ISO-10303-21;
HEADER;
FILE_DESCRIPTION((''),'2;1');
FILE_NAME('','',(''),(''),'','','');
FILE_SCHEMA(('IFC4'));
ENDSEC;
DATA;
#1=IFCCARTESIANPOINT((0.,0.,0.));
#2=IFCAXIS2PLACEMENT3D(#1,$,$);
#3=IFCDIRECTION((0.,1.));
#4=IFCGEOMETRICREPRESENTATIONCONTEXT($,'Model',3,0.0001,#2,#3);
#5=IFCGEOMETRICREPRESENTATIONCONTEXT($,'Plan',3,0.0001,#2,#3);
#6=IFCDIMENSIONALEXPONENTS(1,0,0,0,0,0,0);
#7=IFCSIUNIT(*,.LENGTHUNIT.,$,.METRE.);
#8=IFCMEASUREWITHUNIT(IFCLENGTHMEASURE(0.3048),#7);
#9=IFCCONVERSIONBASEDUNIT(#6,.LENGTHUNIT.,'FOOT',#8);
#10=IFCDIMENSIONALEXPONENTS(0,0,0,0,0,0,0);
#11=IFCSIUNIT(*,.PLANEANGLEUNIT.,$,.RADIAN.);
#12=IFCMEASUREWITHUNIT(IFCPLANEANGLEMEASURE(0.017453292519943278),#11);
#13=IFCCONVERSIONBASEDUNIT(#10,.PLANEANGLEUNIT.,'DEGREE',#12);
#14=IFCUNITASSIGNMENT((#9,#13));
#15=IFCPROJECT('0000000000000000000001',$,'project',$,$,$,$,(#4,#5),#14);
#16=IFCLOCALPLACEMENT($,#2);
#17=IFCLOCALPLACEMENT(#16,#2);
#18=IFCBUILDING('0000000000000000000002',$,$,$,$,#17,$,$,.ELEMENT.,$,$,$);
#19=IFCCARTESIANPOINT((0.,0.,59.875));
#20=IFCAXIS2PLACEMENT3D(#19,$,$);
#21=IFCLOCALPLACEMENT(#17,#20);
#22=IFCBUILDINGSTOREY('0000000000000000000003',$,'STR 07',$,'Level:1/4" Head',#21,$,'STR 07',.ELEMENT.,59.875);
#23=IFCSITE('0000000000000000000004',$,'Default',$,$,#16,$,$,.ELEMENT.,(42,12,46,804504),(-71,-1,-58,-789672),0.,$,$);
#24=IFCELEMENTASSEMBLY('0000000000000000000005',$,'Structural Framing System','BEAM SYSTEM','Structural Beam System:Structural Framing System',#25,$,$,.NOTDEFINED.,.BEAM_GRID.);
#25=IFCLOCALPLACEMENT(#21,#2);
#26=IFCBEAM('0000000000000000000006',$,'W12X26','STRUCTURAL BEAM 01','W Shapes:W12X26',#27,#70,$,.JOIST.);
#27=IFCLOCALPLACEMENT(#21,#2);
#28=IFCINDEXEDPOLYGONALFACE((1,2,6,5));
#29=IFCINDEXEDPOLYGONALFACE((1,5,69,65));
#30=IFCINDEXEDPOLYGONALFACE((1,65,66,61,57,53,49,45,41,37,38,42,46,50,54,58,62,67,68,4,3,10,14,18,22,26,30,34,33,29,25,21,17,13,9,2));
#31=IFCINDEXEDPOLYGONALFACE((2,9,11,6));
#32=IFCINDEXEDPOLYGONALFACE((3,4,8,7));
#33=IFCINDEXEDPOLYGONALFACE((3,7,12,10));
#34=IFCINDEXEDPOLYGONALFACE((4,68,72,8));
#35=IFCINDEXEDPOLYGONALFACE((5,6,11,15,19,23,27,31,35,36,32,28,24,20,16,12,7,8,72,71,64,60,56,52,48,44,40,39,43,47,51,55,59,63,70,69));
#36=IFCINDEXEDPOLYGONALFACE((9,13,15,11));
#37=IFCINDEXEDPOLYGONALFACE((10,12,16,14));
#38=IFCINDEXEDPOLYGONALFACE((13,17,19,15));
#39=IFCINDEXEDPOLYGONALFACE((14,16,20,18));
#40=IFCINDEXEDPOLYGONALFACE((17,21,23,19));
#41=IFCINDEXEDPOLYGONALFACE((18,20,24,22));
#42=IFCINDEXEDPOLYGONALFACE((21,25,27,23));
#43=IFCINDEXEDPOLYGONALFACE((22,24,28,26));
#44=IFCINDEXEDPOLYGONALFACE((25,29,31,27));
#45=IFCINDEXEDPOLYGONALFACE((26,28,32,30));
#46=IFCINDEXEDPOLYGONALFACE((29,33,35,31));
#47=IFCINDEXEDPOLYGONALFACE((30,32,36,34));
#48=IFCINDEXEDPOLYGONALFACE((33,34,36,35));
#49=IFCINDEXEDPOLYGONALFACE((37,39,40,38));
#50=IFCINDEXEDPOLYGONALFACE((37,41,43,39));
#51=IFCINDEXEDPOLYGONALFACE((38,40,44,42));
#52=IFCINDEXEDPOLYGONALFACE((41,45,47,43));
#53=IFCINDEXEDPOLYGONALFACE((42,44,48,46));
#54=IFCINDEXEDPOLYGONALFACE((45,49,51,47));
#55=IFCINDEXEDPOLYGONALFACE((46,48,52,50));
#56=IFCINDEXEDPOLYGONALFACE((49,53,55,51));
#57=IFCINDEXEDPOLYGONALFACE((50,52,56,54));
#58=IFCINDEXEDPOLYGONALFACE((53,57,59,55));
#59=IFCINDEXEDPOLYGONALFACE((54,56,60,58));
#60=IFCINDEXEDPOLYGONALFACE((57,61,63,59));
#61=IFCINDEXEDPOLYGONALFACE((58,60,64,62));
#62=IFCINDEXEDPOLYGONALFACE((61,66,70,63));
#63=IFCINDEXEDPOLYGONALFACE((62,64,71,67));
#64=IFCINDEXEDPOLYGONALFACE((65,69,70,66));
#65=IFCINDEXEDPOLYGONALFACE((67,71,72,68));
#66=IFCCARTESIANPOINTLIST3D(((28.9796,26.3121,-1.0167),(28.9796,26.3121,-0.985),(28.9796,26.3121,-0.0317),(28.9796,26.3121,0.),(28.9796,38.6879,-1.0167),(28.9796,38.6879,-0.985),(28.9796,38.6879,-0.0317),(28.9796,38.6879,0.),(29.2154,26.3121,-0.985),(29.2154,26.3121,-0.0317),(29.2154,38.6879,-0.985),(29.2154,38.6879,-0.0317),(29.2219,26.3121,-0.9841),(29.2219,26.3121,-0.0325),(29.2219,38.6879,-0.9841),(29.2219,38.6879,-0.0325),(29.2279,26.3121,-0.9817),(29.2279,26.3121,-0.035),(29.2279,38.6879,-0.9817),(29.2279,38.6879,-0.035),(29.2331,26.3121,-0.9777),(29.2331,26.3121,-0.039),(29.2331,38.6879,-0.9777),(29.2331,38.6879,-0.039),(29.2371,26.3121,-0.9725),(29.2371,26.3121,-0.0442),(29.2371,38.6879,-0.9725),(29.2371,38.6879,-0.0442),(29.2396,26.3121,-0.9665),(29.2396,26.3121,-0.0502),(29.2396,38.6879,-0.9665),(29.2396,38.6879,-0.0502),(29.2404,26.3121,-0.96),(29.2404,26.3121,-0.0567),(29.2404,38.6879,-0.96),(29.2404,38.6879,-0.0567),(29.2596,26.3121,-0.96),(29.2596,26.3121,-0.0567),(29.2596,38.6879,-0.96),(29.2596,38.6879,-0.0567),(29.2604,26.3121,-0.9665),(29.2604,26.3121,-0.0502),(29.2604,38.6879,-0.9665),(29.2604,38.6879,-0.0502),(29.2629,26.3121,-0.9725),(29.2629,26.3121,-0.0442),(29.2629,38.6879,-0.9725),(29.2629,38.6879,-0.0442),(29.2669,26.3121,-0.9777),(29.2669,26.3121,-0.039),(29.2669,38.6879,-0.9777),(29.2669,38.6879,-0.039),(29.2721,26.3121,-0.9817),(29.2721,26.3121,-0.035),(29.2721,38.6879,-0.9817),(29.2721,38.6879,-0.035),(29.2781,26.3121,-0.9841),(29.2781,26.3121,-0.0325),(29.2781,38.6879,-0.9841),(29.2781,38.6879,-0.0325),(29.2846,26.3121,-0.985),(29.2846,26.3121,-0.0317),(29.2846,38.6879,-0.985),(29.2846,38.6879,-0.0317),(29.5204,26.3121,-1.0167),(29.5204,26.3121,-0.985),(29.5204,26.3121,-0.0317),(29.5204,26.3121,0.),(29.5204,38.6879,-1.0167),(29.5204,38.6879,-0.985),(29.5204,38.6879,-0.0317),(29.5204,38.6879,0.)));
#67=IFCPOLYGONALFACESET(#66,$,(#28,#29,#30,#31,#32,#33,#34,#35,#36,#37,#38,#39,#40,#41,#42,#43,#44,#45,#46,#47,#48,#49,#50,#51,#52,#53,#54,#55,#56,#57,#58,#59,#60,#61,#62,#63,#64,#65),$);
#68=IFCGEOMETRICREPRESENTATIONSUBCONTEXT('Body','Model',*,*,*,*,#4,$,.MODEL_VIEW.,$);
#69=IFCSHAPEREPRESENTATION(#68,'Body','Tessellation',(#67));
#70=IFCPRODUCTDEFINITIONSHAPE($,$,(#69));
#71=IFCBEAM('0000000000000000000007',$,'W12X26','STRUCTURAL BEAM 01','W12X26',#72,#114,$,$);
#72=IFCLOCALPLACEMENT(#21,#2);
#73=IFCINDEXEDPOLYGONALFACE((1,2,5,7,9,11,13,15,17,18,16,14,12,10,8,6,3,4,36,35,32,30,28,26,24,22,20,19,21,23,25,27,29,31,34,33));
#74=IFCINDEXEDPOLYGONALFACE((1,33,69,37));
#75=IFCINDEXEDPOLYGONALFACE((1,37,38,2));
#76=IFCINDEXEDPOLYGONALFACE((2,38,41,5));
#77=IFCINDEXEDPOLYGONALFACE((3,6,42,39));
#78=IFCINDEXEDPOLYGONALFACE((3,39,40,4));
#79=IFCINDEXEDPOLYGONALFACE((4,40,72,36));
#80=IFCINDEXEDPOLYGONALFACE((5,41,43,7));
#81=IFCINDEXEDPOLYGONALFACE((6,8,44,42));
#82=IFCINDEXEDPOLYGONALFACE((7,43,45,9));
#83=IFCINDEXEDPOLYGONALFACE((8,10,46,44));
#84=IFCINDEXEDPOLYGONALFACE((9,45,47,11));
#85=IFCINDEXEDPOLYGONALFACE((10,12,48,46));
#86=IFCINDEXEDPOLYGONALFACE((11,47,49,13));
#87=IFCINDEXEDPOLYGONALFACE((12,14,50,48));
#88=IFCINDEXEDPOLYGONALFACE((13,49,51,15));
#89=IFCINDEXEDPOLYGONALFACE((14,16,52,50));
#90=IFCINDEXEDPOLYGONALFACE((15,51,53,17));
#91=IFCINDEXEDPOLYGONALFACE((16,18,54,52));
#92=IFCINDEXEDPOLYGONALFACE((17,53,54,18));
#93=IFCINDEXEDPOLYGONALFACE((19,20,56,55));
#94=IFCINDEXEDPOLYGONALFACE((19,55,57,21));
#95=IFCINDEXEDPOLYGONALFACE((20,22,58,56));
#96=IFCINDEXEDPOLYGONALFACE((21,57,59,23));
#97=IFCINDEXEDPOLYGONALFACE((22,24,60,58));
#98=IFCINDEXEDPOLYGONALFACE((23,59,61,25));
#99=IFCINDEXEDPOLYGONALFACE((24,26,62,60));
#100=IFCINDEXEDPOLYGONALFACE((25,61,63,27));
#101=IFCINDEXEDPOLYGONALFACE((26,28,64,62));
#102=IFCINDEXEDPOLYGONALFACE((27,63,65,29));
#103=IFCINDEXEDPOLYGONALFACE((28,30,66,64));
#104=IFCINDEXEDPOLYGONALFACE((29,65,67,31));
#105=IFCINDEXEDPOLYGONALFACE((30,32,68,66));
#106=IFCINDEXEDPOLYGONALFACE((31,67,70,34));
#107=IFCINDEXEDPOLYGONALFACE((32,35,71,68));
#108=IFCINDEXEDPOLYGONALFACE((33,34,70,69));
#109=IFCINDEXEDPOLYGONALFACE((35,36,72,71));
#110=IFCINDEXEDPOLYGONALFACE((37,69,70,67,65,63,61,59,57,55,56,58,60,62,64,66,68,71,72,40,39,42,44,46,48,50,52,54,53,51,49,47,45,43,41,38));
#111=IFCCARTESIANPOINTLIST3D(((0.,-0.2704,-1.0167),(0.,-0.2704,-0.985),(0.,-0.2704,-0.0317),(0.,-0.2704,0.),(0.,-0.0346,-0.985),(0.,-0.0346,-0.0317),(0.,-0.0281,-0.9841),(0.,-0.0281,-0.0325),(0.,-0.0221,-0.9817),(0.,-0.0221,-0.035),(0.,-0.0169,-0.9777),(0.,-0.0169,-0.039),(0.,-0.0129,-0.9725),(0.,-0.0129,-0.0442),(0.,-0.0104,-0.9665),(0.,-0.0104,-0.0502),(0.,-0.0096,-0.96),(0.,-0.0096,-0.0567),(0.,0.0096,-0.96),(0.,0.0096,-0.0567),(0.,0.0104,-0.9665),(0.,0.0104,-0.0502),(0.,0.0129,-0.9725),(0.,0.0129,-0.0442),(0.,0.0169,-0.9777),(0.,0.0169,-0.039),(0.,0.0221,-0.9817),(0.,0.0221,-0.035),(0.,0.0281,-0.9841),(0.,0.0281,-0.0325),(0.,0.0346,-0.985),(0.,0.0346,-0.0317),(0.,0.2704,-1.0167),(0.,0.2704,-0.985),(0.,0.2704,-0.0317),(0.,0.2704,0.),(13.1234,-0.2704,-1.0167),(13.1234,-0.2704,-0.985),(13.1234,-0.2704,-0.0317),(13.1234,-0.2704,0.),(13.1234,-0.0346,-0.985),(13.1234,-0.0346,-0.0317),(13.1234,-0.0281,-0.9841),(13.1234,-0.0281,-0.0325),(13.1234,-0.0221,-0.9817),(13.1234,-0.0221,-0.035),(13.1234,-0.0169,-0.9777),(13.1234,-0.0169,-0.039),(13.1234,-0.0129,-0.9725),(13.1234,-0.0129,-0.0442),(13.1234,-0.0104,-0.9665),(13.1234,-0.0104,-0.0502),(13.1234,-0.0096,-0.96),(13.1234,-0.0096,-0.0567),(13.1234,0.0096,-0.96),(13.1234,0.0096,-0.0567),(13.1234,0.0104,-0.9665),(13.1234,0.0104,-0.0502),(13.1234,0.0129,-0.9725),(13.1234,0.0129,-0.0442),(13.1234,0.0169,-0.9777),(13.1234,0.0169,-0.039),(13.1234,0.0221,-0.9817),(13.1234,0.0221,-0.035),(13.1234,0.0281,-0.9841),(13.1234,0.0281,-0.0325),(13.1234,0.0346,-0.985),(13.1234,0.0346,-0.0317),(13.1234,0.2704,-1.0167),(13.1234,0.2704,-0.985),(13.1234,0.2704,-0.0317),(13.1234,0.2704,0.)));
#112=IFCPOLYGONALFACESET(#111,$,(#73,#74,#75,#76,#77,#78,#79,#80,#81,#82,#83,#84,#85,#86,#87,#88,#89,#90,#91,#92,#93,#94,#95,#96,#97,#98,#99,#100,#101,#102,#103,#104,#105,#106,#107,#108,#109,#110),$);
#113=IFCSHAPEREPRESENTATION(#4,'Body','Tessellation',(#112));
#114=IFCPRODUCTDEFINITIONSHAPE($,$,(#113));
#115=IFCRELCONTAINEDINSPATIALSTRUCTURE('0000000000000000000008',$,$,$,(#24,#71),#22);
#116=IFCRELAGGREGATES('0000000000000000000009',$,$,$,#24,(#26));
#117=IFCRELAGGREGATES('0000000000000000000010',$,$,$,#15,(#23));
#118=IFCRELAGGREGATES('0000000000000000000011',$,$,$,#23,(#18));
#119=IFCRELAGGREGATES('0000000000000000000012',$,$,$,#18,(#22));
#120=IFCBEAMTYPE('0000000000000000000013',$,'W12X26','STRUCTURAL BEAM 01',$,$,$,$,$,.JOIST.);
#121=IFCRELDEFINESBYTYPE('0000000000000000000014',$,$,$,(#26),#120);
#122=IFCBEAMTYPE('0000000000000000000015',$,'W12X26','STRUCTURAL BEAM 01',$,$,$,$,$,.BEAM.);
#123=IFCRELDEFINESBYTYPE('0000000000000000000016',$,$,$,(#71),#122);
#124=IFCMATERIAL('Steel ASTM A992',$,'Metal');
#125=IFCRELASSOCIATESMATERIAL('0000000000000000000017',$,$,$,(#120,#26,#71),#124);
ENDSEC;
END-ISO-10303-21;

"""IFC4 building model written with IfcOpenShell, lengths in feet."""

from ifc_helpers import new_model, entity, si_unit, converted_unit, direction, frame, origin, origin_2d, place, context, subcontext, project, spatial, line, arc, indexed_curve, i_section, outline, extrude, source, transform, mapped, material, type_object, type_shapes, element, aggregate, save


model = new_model("IFC4")

# Units and contexts
model_context = context("Model", 3, precision=0.0001, world=origin(), true_north=direction((0.0, 1.0)))
plan_context = context("Plan", 3, precision=0.0001, world=origin(), true_north=direction((0.0, 1.0)))
body_context = subcontext(model_context, "Body", "Model", "MODEL_VIEW")
ifc_project = project(units=[converted_unit("LENGTHUNIT", "FOOT", entity("IfcLengthMeasure", 0.3048), si_unit("LENGTHUNIT", "METRE"), dimensions=[1, 0, 0, 0, 0, 0, 0]), converted_unit("PLANEANGLEUNIT", "DEGREE", entity("IfcPlaneAngleMeasure", 0.017453292519943278), si_unit("PLANEANGLEUNIT", "RADIAN"), dimensions=[0, 0, 0, 0, 0, 0, 0])], contexts=[model_context, plan_context])

# Site, building, storey
site_placement = place(None, origin())
site = spatial("IfcSite", under=ifc_project, at=site_placement, Name="Default", CompositionType="ELEMENT", RefLatitude=(42, 12, 46, 804504), RefLongitude=(-71, -1, -58, -789672), RefElevation=0.0)
building_placement = place(site_placement, origin())
building = spatial("IfcBuilding", under=site, at=building_placement, CompositionType="ELEMENT")
storey_placement = place(building_placement, frame((0.0, 0.0, 59.875)))
storey = spatial("IfcBuildingStorey", under=building, at=storey_placement, Name="STR 07", ObjectType="Level:1/4\" Head", LongName="STR 07", CompositionType="ELEMENT", Elevation=59.875)

# Shared definitions
ifc_material = material(Name="Steel ASTM A992", Category="Metal")
beam_type_1 = type_object("IfcBeamType", Name="W12X26", Description="STRUCTURAL BEAM 01", PredefinedType="JOIST", material=ifc_material)
shared_shape = source(origin(), body_context, "Body", "SweptSolid", [
    extrude(outline(indexed_curve([(-0.2704, -0.4767), (-0.2704, -0.5083), (0.2704, -0.5083), (0.2704, -0.4767), (0.0346, -0.4767), (0.0169, -0.4693), (0.0096, -0.4517), (0.0096, 0.4517), (0.0169, 0.4693), (0.0346, 0.4767), (0.2704, 0.4767), (0.2704, 0.5083), (-0.2704, 0.5083), (-0.2704, 0.4767), (-0.0346, 0.4767), (-0.0169, 0.4693), (-0.0096, 0.4517), (-0.0096, -0.4517), (-0.0169, -0.4693), (-0.0346, -0.4767)], segments=[line(1, 2, 3, 4, 5), arc(5, 6, 7), line(7, 8), arc(8, 9, 10), line(10, 11, 12, 13, 14, 15), arc(15, 16, 17), line(17, 18), arc(18, 19, 20), line(20, 1)], self_intersect=False)), frame((-6.1879, 0.0, 0.0), z_axis=(-1.0, 0.0, 0.0), x_axis=(0.0, -1.0, 0.0)), (0.0, 0.0, -1.0), 12.3758),
])
type_shapes(beam_type_1, [shared_shape])

# Element assembly, beam
assembly_1_placement = place(storey_placement, origin())
assembly_1 = element("IfcElementAssembly", 1, at=assembly_1_placement, inside=storey, Name="Structural Framing System", Description="BEAM SYSTEM", ObjectType="Structural Beam System:Structural Framing System", AssemblyPlace="NOTDEFINED", PredefinedType="BEAM_GRID")
beam_1_placement = place(assembly_1_placement, frame((29.25, 32.5, -0.5083), z_axis=(0.0, 0.0, 1.0), x_axis=(0.0, 1.0, 0.0)))
beam_1 = element("IfcBeam", 2, at=beam_1_placement, type_object=beam_type_1, material=ifc_material, Name="W12X26", Description="STRUCTURAL BEAM 01", ObjectType="W Shapes:W12X26", PredefinedType="JOIST", context=body_context, shape_type="MappedRepresentation", body=[
    mapped(shared_shape, transform((0.0, 0.0, 0.0), scale=1.0)),
])
aggregate(assembly_1, [beam_1])

# Beam
beam_type_2 = type_object("IfcBeamType", Name="W12X26", Description="STRUCTURAL BEAM 01", PredefinedType="BEAM")
beam_2_placement = place(storey_placement, frame((0.0, 0.0, -0.5083), z_axis=(-1.0, 0.0, 0.0), x_axis=(0.0, -1.0, 0.0)))
element("IfcBeam", 3, at=beam_2_placement, inside=storey, type_object=beam_type_2, material=ifc_material, Name="W12X26", Description="STRUCTURAL BEAM 01", ObjectType="W12X26", context=model_context, shape_type="SweptSolid", body=[
    extrude(i_section(OverallWidth=0.5408, OverallDepth=1.0167, WebThickness=0.0192, FlangeThickness=0.0317, FilletRadius=0.025, at=origin_2d()), origin(), (0.0, 0.0, -1.0), 13.1234),
])

save(model, "model.ifc")
